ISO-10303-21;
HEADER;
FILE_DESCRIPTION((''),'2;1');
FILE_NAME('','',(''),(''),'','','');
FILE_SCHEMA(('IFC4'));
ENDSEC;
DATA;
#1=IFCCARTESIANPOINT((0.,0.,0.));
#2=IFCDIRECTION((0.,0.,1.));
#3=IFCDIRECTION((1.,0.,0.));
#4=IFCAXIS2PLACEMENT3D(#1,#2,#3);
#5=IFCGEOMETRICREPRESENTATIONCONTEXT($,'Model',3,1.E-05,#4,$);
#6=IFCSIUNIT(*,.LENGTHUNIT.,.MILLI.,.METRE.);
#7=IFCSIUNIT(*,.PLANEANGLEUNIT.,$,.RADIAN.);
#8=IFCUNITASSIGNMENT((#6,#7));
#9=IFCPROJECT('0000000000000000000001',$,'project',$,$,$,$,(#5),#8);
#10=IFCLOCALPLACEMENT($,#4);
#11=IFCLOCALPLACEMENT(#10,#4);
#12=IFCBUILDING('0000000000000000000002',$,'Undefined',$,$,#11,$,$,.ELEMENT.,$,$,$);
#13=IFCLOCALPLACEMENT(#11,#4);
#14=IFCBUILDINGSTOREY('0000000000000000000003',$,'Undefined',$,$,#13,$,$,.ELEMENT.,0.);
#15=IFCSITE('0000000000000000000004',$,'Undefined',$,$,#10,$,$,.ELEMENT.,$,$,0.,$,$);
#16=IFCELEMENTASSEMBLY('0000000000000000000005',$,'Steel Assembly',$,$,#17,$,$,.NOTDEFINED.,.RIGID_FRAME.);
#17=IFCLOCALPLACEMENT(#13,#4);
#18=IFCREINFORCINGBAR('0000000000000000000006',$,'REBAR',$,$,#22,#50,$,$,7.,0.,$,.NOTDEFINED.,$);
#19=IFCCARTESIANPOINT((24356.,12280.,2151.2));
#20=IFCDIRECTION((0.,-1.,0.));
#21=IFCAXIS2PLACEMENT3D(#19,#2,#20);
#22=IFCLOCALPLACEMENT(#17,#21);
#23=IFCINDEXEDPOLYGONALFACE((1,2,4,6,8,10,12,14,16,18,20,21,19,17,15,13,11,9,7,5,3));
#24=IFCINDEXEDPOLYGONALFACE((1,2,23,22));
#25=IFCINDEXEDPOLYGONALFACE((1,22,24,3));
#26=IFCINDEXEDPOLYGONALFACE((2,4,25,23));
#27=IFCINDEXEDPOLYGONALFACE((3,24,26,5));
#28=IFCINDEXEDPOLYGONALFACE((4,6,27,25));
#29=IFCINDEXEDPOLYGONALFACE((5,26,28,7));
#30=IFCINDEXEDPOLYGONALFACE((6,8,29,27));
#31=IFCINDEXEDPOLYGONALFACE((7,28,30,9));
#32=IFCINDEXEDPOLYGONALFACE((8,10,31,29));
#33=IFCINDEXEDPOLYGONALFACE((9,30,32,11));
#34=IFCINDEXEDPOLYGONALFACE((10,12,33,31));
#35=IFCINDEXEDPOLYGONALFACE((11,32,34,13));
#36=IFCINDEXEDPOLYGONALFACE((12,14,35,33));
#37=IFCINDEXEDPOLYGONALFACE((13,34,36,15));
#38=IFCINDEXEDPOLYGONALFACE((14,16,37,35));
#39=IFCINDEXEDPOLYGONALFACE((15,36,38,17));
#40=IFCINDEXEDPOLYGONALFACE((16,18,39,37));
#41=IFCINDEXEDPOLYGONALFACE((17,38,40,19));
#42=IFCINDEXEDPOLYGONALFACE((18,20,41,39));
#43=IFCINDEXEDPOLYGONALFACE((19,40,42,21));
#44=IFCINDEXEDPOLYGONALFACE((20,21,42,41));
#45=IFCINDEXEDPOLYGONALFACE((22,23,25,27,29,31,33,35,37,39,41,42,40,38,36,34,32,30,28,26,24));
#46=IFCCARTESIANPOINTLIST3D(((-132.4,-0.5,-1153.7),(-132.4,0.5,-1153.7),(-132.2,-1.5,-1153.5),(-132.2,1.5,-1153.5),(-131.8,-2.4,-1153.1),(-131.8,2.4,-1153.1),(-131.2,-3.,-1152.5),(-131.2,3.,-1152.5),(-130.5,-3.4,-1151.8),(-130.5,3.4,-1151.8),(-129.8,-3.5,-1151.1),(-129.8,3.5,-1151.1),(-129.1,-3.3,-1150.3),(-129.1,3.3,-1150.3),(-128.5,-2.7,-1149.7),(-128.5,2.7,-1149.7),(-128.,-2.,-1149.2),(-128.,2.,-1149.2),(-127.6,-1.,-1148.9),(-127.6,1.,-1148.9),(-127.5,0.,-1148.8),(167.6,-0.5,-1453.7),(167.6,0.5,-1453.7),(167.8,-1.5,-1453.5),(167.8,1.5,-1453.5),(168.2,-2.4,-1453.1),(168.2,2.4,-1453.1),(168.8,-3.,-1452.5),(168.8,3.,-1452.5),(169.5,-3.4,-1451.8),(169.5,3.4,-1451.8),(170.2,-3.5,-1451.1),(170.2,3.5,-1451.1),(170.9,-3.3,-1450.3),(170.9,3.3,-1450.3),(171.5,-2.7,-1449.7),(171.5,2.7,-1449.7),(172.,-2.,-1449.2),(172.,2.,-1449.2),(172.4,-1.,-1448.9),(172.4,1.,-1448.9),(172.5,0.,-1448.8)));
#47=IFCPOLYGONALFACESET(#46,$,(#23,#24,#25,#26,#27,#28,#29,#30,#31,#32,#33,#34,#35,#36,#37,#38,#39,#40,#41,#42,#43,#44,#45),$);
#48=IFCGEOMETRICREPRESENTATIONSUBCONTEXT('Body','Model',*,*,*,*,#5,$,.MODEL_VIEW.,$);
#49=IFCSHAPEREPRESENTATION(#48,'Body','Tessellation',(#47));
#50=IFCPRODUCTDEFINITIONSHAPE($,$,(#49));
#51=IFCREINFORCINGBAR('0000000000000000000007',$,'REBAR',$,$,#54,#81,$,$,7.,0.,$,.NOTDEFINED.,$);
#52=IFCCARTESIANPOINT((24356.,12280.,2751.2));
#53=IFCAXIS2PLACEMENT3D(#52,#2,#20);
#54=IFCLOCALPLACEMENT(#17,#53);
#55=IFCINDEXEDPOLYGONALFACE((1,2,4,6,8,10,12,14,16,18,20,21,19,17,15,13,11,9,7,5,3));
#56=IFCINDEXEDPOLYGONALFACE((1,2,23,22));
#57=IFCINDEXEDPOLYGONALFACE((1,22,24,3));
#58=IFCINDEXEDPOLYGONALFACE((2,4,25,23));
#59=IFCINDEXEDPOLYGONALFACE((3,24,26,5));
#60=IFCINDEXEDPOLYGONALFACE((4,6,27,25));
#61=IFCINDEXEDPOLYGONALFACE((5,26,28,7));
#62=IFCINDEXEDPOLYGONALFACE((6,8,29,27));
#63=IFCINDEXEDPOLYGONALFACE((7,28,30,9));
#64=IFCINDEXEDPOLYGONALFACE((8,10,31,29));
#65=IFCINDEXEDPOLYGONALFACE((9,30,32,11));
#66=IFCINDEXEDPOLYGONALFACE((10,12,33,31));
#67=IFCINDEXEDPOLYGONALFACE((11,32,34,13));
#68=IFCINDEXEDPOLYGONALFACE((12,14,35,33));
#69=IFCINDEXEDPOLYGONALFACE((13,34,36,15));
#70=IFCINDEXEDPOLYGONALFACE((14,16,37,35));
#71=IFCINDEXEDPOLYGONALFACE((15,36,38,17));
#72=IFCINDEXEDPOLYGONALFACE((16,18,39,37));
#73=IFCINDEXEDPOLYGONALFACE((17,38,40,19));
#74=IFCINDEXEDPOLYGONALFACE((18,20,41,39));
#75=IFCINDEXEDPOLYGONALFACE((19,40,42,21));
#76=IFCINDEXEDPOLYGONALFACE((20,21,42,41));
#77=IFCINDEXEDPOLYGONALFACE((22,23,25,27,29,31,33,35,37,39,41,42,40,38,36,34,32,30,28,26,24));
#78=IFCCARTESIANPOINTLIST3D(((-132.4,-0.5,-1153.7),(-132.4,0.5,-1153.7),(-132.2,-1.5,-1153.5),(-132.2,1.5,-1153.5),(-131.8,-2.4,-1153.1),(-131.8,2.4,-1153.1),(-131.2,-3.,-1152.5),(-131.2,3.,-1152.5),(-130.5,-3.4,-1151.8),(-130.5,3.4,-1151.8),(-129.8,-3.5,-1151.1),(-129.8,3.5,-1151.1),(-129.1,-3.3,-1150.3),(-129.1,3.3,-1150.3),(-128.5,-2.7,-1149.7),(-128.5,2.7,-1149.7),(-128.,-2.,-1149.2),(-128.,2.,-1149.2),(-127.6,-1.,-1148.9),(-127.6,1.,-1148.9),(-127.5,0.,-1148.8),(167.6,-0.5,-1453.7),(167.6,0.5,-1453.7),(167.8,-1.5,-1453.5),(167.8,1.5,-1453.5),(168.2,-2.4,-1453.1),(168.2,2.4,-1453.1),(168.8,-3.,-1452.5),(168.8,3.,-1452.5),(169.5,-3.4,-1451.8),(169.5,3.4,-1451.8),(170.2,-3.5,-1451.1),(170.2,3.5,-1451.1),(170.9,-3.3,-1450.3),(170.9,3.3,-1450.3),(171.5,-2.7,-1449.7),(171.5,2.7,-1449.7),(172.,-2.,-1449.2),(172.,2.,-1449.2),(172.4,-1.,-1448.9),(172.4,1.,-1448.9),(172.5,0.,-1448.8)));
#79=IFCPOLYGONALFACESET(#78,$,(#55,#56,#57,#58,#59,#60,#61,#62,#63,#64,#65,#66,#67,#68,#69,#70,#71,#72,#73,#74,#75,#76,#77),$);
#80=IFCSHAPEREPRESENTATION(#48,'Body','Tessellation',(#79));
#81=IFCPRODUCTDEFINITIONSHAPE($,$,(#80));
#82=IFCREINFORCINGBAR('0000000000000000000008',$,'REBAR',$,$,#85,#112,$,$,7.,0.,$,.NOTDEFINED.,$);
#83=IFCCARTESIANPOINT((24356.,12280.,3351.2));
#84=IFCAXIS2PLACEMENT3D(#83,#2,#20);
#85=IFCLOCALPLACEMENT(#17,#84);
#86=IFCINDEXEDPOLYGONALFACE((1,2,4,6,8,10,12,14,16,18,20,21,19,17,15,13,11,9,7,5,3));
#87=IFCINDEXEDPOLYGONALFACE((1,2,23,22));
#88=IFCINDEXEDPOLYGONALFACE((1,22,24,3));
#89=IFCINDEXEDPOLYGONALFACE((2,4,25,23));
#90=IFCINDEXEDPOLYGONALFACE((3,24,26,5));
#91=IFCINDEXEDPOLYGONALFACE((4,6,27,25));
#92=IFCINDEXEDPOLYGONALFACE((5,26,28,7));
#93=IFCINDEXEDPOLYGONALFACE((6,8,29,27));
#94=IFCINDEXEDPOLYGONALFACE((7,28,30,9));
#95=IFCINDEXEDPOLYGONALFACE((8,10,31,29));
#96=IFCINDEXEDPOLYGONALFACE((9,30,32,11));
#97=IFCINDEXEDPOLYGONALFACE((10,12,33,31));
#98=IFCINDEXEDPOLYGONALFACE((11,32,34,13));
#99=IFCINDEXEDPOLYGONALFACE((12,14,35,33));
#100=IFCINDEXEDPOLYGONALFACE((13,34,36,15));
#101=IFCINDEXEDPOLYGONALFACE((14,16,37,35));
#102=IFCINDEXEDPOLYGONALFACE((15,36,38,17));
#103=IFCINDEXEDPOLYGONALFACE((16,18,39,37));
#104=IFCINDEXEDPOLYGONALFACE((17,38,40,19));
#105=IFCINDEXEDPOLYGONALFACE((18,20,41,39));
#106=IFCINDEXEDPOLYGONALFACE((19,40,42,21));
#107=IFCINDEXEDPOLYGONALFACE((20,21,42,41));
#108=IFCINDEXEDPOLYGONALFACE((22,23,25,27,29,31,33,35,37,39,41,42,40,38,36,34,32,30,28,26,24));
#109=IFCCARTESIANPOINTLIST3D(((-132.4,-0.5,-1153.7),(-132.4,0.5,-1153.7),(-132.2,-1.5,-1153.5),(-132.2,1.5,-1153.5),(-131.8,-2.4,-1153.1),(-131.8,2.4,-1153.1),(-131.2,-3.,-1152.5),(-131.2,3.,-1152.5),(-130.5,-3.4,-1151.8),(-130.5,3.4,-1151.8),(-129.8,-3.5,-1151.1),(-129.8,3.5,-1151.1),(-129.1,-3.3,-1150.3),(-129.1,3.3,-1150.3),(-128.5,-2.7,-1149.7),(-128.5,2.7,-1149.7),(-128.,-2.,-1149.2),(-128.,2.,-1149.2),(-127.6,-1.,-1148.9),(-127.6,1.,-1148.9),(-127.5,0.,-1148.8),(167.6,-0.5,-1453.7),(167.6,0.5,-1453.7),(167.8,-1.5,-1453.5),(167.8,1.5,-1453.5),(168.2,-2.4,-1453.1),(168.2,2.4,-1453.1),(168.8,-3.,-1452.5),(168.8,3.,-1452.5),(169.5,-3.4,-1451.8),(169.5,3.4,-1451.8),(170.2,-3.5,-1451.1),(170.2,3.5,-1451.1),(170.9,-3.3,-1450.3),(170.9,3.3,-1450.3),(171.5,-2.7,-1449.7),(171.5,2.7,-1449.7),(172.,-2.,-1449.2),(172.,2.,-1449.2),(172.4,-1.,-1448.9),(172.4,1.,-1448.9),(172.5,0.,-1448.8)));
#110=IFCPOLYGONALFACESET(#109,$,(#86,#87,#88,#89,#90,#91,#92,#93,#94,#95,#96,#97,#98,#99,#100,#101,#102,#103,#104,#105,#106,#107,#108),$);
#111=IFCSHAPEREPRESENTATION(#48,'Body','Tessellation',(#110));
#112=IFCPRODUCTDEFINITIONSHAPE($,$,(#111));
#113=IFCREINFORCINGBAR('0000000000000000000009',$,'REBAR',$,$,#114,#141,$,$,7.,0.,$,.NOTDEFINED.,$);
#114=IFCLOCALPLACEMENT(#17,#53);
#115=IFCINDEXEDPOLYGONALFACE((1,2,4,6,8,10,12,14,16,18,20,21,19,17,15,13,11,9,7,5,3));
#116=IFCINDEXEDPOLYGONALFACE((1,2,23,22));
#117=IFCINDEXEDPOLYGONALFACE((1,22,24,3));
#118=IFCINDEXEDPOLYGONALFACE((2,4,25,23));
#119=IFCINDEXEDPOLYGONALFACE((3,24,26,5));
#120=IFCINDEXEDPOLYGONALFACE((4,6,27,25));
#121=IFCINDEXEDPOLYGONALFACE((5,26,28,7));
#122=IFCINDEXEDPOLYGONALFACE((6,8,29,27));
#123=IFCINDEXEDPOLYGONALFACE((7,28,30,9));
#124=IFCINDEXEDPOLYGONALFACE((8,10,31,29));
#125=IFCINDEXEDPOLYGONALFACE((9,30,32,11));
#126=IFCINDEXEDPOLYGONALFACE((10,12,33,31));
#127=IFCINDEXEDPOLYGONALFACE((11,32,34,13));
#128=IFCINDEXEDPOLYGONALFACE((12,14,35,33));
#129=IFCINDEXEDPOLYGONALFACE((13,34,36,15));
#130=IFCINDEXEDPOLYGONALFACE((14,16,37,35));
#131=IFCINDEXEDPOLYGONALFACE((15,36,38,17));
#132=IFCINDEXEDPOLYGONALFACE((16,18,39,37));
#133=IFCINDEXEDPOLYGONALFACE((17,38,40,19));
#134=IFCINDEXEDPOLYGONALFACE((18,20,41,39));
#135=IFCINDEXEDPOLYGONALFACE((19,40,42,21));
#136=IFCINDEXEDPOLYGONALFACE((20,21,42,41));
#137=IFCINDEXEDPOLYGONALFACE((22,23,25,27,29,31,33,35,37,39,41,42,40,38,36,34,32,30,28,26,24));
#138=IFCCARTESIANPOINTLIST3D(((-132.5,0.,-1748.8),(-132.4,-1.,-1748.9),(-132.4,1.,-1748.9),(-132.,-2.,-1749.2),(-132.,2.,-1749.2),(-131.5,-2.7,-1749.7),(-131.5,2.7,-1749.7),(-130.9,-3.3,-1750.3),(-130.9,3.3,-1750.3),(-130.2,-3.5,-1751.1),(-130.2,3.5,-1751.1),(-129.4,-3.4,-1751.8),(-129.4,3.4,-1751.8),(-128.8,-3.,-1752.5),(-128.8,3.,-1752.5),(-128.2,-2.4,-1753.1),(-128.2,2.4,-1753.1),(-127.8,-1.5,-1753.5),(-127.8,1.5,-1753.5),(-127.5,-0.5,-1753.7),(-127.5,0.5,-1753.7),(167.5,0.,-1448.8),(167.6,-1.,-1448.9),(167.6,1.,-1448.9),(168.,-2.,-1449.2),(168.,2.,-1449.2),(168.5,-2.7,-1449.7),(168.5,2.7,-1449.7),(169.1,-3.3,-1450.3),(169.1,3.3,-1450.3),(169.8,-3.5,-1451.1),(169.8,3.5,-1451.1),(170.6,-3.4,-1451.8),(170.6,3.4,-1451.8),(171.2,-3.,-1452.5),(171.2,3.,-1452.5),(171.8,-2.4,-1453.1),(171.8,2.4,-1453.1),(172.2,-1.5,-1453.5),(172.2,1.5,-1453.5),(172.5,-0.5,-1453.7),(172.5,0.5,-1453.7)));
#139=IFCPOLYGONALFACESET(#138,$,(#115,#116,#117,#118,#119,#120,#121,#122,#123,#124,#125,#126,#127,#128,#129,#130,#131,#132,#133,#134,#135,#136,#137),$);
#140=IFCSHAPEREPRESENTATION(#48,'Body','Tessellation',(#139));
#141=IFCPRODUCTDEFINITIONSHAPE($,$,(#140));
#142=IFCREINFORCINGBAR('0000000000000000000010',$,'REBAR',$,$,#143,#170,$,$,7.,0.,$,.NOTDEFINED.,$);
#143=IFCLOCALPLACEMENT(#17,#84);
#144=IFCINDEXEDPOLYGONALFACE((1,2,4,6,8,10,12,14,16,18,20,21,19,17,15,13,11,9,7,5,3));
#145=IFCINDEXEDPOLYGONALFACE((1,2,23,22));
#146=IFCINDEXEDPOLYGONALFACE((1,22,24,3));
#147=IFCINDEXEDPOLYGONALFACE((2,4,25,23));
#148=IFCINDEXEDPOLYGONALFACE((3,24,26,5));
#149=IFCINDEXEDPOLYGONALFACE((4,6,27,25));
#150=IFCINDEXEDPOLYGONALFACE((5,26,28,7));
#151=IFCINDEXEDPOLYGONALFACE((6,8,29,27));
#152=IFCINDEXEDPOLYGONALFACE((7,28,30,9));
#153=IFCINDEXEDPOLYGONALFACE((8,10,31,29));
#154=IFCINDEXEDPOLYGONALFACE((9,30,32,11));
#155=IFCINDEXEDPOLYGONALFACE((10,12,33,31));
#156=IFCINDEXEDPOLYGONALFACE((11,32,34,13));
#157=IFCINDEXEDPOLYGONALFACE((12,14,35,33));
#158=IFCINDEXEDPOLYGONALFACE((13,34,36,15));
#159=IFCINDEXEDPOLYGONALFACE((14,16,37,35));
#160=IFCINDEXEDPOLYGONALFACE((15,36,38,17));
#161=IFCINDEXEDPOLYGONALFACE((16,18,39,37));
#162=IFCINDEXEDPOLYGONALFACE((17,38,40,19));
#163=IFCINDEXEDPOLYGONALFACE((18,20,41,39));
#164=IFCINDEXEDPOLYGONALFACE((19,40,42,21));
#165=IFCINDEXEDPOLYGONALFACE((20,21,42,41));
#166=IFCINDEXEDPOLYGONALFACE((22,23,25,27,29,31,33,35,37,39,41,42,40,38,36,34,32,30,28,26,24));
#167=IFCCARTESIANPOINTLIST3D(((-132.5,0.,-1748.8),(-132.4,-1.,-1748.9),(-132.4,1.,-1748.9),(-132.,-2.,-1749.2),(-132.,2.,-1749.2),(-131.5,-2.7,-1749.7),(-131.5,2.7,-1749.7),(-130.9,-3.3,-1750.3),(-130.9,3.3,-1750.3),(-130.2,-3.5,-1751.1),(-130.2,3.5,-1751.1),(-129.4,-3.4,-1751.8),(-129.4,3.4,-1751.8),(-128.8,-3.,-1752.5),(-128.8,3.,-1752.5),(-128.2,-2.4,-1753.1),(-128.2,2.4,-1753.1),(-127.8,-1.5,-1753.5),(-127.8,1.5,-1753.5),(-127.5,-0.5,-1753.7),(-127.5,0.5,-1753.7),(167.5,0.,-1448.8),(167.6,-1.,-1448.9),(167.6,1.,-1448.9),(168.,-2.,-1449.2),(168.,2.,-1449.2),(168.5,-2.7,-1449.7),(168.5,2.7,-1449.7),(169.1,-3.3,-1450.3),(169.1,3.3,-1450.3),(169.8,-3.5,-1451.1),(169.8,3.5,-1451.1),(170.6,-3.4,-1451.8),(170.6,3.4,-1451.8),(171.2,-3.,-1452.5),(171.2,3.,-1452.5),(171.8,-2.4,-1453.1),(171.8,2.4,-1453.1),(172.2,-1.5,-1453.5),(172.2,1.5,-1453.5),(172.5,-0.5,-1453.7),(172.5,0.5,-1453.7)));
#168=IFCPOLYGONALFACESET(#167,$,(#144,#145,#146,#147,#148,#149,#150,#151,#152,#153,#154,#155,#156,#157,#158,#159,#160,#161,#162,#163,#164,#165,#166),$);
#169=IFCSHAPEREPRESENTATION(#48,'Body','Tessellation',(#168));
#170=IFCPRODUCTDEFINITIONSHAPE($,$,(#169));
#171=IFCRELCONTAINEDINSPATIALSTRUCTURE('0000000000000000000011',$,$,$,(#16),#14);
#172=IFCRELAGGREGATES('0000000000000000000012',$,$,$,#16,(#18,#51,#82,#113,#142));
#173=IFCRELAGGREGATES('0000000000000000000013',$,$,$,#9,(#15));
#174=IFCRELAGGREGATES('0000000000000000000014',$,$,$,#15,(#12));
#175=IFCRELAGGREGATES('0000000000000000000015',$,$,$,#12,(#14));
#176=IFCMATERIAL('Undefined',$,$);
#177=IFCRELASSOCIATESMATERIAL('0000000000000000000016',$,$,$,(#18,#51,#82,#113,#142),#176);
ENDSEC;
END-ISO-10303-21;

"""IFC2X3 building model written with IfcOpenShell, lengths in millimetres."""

from ifc_helpers import new_model, entity, si_unit, frame, origin_with_axes, place, context, subcontext, project, spatial, source, transform, mapped, material, element, aggregate, save


model = new_model("IFC2X3")

# Units and contexts
model_context = context("Model", 3, precision=1e-05, world=origin_with_axes())
body_context = subcontext(model_context, "Body", "Model", "MODEL_VIEW")
ifc_project = project(units=[si_unit("LENGTHUNIT", "METRE", prefix="MILLI"), si_unit("PLANEANGLEUNIT", "RADIAN")], contexts=[model_context])

# Site, building, storey
site_placement = place(None, origin_with_axes())
site = spatial("IfcSite", under=ifc_project, at=site_placement, Name="Undefined", CompositionType="ELEMENT", RefElevation=0.0)
building_placement = place(site_placement, origin_with_axes())
building = spatial("IfcBuilding", under=site, at=building_placement, Name="Undefined", CompositionType="ELEMENT")
storey_placement = place(building_placement, origin_with_axes())
storey = spatial("IfcBuildingStorey", under=building, at=storey_placement, Name="Undefined", CompositionType="ELEMENT", Elevation=0.0)

# Shared definitions
ifc_material_1 = material(Name="Undefined")

# Element assembly, reinforcing bars
assembly_1_placement = place(storey_placement, origin_with_axes())
assembly_1 = element("IfcElementAssembly", 1, at=assembly_1_placement, inside=storey, Name="Steel Assembly", AssemblyPlace="NOTDEFINED", PredefinedType="RIGID_FRAME")
shared_shape_1 = source(origin_with_axes(), body_context, "Body", "AdvancedSweptSolid", [
    entity("IfcSweptDiskSolid", entity("IfcTrimmedCurve", entity("IfcLine", entity("IfcCartesianPoint", [0.0, 0.0, 0.0]), entity("IfcVector", entity("IfcDirection", [0.707107, 0.0, -0.707107]), 1.0)), [entity("IfcParameterValue", 0.0)], [entity("IfcParameterValue", 424.264069)], True, "PARAMETER"), 3.5, None, 0.0, 424.3),
])
reinforcing_bar_1_placement = place(assembly_1_placement, frame((24356.0, 12280.0, 2151.2), z_axis=(0.0, 0.0, 1.0), x_axis=(0.0, -1.0, 0.0)))
reinforcing_bar_1 = element("IfcReinforcingBar", 2, at=reinforcing_bar_1_placement, material=ifc_material_1, Name="REBAR", BarRole="NOTDEFINED", CrossSectionArea=0.0, NominalDiameter=7.0, context=body_context, shape_type="MappedRepresentation", body=[
    mapped(shared_shape_1, transform((-130.0, 0.0, -1151.2))),
])
shared_shape_2 = source(origin_with_axes(), body_context, "Body", "AdvancedSweptSolid", [
    entity("IfcSweptDiskSolid", entity("IfcTrimmedCurve", entity("IfcLine", entity("IfcCartesianPoint", [0.0, 0.0, 0.0]), entity("IfcVector", entity("IfcDirection", [0.707107, 0.0, -0.707107]), 1.0)), [entity("IfcParameterValue", 0.0)], [entity("IfcParameterValue", 424.264069)], True, "PARAMETER"), 3.5, None, 0.0, 424.3),
])
reinforcing_bar_2_placement = place(assembly_1_placement, frame((24356.0, 12280.0, 2751.2), z_axis=(0.0, 0.0, 1.0), x_axis=(0.0, -1.0, 0.0)))
reinforcing_bar_2 = element("IfcReinforcingBar", 3, at=reinforcing_bar_2_placement, material=ifc_material_1, Name="REBAR", BarRole="NOTDEFINED", CrossSectionArea=0.0, NominalDiameter=7.0, context=body_context, shape_type="MappedRepresentation", body=[
    mapped(shared_shape_2, transform((-130.0, 0.0, -1151.2))),
])
shared_shape_3 = source(origin_with_axes(), body_context, "Body", "AdvancedSweptSolid", [
    entity("IfcSweptDiskSolid", entity("IfcTrimmedCurve", entity("IfcLine", entity("IfcCartesianPoint", [0.0, 0.0, 0.0]), entity("IfcVector", entity("IfcDirection", [0.707107, 0.0, -0.707107]), 1.0)), [entity("IfcParameterValue", 0.0)], [entity("IfcParameterValue", 424.264069)], True, "PARAMETER"), 3.5, None, 0.0, 424.3),
])
reinforcing_bar_3_placement = place(assembly_1_placement, frame((24356.0, 12280.0, 3351.2), z_axis=(0.0, 0.0, 1.0), x_axis=(0.0, -1.0, 0.0)))
reinforcing_bar_3 = element("IfcReinforcingBar", 4, at=reinforcing_bar_3_placement, material=ifc_material_1, Name="REBAR", BarRole="NOTDEFINED", CrossSectionArea=0.0, NominalDiameter=7.0, context=body_context, shape_type="MappedRepresentation", body=[
    mapped(shared_shape_3, transform((-130.0, 0.0, -1151.2))),
])
shared_shape_4 = source(origin_with_axes(), body_context, "Body", "AdvancedSweptSolid", [
    entity("IfcSweptDiskSolid", entity("IfcTrimmedCurve", entity("IfcLine", entity("IfcCartesianPoint", [0.0, 0.0, 0.0]), entity("IfcVector", entity("IfcDirection", [0.707107, 0.0, 0.707107]), 1.0)), [entity("IfcParameterValue", 0.0)], [entity("IfcParameterValue", 424.264069)], True, "PARAMETER"), 3.5, None, 0.0, 424.3),
])
reinforcing_bar_4_placement = place(assembly_1_placement, frame((24356.0, 12280.0, 2751.2), z_axis=(0.0, 0.0, 1.0), x_axis=(0.0, -1.0, 0.0)))
reinforcing_bar_4 = element("IfcReinforcingBar", 5, at=reinforcing_bar_4_placement, material=ifc_material_1, Name="REBAR", BarRole="NOTDEFINED", CrossSectionArea=0.0, NominalDiameter=7.0, context=body_context, shape_type="MappedRepresentation", body=[
    mapped(shared_shape_4, transform((-130.0, 0.0, -1751.2))),
])
shared_shape_5 = source(origin_with_axes(), body_context, "Body", "AdvancedSweptSolid", [
    entity("IfcSweptDiskSolid", entity("IfcTrimmedCurve", entity("IfcLine", entity("IfcCartesianPoint", [0.0, 0.0, 0.0]), entity("IfcVector", entity("IfcDirection", [0.707107, 0.0, 0.707107]), 1.0)), [entity("IfcParameterValue", 0.0)], [entity("IfcParameterValue", 424.264069)], True, "PARAMETER"), 3.5, None, 0.0, 424.3),
])
reinforcing_bar_5_placement = place(assembly_1_placement, frame((24356.0, 12280.0, 3351.2), z_axis=(0.0, 0.0, 1.0), x_axis=(0.0, -1.0, 0.0)))
reinforcing_bar_5 = element("IfcReinforcingBar", 6, at=reinforcing_bar_5_placement, material=ifc_material_1, Name="REBAR", BarRole="NOTDEFINED", CrossSectionArea=0.0, NominalDiameter=7.0, context=body_context, shape_type="MappedRepresentation", body=[
    mapped(shared_shape_5, transform((-130.0, 0.0, -1751.2))),
])
aggregate(assembly_1, [reinforcing_bar_1, reinforcing_bar_2, reinforcing_bar_3, reinforcing_bar_4, reinforcing_bar_5])

save(model, "model.ifc")
